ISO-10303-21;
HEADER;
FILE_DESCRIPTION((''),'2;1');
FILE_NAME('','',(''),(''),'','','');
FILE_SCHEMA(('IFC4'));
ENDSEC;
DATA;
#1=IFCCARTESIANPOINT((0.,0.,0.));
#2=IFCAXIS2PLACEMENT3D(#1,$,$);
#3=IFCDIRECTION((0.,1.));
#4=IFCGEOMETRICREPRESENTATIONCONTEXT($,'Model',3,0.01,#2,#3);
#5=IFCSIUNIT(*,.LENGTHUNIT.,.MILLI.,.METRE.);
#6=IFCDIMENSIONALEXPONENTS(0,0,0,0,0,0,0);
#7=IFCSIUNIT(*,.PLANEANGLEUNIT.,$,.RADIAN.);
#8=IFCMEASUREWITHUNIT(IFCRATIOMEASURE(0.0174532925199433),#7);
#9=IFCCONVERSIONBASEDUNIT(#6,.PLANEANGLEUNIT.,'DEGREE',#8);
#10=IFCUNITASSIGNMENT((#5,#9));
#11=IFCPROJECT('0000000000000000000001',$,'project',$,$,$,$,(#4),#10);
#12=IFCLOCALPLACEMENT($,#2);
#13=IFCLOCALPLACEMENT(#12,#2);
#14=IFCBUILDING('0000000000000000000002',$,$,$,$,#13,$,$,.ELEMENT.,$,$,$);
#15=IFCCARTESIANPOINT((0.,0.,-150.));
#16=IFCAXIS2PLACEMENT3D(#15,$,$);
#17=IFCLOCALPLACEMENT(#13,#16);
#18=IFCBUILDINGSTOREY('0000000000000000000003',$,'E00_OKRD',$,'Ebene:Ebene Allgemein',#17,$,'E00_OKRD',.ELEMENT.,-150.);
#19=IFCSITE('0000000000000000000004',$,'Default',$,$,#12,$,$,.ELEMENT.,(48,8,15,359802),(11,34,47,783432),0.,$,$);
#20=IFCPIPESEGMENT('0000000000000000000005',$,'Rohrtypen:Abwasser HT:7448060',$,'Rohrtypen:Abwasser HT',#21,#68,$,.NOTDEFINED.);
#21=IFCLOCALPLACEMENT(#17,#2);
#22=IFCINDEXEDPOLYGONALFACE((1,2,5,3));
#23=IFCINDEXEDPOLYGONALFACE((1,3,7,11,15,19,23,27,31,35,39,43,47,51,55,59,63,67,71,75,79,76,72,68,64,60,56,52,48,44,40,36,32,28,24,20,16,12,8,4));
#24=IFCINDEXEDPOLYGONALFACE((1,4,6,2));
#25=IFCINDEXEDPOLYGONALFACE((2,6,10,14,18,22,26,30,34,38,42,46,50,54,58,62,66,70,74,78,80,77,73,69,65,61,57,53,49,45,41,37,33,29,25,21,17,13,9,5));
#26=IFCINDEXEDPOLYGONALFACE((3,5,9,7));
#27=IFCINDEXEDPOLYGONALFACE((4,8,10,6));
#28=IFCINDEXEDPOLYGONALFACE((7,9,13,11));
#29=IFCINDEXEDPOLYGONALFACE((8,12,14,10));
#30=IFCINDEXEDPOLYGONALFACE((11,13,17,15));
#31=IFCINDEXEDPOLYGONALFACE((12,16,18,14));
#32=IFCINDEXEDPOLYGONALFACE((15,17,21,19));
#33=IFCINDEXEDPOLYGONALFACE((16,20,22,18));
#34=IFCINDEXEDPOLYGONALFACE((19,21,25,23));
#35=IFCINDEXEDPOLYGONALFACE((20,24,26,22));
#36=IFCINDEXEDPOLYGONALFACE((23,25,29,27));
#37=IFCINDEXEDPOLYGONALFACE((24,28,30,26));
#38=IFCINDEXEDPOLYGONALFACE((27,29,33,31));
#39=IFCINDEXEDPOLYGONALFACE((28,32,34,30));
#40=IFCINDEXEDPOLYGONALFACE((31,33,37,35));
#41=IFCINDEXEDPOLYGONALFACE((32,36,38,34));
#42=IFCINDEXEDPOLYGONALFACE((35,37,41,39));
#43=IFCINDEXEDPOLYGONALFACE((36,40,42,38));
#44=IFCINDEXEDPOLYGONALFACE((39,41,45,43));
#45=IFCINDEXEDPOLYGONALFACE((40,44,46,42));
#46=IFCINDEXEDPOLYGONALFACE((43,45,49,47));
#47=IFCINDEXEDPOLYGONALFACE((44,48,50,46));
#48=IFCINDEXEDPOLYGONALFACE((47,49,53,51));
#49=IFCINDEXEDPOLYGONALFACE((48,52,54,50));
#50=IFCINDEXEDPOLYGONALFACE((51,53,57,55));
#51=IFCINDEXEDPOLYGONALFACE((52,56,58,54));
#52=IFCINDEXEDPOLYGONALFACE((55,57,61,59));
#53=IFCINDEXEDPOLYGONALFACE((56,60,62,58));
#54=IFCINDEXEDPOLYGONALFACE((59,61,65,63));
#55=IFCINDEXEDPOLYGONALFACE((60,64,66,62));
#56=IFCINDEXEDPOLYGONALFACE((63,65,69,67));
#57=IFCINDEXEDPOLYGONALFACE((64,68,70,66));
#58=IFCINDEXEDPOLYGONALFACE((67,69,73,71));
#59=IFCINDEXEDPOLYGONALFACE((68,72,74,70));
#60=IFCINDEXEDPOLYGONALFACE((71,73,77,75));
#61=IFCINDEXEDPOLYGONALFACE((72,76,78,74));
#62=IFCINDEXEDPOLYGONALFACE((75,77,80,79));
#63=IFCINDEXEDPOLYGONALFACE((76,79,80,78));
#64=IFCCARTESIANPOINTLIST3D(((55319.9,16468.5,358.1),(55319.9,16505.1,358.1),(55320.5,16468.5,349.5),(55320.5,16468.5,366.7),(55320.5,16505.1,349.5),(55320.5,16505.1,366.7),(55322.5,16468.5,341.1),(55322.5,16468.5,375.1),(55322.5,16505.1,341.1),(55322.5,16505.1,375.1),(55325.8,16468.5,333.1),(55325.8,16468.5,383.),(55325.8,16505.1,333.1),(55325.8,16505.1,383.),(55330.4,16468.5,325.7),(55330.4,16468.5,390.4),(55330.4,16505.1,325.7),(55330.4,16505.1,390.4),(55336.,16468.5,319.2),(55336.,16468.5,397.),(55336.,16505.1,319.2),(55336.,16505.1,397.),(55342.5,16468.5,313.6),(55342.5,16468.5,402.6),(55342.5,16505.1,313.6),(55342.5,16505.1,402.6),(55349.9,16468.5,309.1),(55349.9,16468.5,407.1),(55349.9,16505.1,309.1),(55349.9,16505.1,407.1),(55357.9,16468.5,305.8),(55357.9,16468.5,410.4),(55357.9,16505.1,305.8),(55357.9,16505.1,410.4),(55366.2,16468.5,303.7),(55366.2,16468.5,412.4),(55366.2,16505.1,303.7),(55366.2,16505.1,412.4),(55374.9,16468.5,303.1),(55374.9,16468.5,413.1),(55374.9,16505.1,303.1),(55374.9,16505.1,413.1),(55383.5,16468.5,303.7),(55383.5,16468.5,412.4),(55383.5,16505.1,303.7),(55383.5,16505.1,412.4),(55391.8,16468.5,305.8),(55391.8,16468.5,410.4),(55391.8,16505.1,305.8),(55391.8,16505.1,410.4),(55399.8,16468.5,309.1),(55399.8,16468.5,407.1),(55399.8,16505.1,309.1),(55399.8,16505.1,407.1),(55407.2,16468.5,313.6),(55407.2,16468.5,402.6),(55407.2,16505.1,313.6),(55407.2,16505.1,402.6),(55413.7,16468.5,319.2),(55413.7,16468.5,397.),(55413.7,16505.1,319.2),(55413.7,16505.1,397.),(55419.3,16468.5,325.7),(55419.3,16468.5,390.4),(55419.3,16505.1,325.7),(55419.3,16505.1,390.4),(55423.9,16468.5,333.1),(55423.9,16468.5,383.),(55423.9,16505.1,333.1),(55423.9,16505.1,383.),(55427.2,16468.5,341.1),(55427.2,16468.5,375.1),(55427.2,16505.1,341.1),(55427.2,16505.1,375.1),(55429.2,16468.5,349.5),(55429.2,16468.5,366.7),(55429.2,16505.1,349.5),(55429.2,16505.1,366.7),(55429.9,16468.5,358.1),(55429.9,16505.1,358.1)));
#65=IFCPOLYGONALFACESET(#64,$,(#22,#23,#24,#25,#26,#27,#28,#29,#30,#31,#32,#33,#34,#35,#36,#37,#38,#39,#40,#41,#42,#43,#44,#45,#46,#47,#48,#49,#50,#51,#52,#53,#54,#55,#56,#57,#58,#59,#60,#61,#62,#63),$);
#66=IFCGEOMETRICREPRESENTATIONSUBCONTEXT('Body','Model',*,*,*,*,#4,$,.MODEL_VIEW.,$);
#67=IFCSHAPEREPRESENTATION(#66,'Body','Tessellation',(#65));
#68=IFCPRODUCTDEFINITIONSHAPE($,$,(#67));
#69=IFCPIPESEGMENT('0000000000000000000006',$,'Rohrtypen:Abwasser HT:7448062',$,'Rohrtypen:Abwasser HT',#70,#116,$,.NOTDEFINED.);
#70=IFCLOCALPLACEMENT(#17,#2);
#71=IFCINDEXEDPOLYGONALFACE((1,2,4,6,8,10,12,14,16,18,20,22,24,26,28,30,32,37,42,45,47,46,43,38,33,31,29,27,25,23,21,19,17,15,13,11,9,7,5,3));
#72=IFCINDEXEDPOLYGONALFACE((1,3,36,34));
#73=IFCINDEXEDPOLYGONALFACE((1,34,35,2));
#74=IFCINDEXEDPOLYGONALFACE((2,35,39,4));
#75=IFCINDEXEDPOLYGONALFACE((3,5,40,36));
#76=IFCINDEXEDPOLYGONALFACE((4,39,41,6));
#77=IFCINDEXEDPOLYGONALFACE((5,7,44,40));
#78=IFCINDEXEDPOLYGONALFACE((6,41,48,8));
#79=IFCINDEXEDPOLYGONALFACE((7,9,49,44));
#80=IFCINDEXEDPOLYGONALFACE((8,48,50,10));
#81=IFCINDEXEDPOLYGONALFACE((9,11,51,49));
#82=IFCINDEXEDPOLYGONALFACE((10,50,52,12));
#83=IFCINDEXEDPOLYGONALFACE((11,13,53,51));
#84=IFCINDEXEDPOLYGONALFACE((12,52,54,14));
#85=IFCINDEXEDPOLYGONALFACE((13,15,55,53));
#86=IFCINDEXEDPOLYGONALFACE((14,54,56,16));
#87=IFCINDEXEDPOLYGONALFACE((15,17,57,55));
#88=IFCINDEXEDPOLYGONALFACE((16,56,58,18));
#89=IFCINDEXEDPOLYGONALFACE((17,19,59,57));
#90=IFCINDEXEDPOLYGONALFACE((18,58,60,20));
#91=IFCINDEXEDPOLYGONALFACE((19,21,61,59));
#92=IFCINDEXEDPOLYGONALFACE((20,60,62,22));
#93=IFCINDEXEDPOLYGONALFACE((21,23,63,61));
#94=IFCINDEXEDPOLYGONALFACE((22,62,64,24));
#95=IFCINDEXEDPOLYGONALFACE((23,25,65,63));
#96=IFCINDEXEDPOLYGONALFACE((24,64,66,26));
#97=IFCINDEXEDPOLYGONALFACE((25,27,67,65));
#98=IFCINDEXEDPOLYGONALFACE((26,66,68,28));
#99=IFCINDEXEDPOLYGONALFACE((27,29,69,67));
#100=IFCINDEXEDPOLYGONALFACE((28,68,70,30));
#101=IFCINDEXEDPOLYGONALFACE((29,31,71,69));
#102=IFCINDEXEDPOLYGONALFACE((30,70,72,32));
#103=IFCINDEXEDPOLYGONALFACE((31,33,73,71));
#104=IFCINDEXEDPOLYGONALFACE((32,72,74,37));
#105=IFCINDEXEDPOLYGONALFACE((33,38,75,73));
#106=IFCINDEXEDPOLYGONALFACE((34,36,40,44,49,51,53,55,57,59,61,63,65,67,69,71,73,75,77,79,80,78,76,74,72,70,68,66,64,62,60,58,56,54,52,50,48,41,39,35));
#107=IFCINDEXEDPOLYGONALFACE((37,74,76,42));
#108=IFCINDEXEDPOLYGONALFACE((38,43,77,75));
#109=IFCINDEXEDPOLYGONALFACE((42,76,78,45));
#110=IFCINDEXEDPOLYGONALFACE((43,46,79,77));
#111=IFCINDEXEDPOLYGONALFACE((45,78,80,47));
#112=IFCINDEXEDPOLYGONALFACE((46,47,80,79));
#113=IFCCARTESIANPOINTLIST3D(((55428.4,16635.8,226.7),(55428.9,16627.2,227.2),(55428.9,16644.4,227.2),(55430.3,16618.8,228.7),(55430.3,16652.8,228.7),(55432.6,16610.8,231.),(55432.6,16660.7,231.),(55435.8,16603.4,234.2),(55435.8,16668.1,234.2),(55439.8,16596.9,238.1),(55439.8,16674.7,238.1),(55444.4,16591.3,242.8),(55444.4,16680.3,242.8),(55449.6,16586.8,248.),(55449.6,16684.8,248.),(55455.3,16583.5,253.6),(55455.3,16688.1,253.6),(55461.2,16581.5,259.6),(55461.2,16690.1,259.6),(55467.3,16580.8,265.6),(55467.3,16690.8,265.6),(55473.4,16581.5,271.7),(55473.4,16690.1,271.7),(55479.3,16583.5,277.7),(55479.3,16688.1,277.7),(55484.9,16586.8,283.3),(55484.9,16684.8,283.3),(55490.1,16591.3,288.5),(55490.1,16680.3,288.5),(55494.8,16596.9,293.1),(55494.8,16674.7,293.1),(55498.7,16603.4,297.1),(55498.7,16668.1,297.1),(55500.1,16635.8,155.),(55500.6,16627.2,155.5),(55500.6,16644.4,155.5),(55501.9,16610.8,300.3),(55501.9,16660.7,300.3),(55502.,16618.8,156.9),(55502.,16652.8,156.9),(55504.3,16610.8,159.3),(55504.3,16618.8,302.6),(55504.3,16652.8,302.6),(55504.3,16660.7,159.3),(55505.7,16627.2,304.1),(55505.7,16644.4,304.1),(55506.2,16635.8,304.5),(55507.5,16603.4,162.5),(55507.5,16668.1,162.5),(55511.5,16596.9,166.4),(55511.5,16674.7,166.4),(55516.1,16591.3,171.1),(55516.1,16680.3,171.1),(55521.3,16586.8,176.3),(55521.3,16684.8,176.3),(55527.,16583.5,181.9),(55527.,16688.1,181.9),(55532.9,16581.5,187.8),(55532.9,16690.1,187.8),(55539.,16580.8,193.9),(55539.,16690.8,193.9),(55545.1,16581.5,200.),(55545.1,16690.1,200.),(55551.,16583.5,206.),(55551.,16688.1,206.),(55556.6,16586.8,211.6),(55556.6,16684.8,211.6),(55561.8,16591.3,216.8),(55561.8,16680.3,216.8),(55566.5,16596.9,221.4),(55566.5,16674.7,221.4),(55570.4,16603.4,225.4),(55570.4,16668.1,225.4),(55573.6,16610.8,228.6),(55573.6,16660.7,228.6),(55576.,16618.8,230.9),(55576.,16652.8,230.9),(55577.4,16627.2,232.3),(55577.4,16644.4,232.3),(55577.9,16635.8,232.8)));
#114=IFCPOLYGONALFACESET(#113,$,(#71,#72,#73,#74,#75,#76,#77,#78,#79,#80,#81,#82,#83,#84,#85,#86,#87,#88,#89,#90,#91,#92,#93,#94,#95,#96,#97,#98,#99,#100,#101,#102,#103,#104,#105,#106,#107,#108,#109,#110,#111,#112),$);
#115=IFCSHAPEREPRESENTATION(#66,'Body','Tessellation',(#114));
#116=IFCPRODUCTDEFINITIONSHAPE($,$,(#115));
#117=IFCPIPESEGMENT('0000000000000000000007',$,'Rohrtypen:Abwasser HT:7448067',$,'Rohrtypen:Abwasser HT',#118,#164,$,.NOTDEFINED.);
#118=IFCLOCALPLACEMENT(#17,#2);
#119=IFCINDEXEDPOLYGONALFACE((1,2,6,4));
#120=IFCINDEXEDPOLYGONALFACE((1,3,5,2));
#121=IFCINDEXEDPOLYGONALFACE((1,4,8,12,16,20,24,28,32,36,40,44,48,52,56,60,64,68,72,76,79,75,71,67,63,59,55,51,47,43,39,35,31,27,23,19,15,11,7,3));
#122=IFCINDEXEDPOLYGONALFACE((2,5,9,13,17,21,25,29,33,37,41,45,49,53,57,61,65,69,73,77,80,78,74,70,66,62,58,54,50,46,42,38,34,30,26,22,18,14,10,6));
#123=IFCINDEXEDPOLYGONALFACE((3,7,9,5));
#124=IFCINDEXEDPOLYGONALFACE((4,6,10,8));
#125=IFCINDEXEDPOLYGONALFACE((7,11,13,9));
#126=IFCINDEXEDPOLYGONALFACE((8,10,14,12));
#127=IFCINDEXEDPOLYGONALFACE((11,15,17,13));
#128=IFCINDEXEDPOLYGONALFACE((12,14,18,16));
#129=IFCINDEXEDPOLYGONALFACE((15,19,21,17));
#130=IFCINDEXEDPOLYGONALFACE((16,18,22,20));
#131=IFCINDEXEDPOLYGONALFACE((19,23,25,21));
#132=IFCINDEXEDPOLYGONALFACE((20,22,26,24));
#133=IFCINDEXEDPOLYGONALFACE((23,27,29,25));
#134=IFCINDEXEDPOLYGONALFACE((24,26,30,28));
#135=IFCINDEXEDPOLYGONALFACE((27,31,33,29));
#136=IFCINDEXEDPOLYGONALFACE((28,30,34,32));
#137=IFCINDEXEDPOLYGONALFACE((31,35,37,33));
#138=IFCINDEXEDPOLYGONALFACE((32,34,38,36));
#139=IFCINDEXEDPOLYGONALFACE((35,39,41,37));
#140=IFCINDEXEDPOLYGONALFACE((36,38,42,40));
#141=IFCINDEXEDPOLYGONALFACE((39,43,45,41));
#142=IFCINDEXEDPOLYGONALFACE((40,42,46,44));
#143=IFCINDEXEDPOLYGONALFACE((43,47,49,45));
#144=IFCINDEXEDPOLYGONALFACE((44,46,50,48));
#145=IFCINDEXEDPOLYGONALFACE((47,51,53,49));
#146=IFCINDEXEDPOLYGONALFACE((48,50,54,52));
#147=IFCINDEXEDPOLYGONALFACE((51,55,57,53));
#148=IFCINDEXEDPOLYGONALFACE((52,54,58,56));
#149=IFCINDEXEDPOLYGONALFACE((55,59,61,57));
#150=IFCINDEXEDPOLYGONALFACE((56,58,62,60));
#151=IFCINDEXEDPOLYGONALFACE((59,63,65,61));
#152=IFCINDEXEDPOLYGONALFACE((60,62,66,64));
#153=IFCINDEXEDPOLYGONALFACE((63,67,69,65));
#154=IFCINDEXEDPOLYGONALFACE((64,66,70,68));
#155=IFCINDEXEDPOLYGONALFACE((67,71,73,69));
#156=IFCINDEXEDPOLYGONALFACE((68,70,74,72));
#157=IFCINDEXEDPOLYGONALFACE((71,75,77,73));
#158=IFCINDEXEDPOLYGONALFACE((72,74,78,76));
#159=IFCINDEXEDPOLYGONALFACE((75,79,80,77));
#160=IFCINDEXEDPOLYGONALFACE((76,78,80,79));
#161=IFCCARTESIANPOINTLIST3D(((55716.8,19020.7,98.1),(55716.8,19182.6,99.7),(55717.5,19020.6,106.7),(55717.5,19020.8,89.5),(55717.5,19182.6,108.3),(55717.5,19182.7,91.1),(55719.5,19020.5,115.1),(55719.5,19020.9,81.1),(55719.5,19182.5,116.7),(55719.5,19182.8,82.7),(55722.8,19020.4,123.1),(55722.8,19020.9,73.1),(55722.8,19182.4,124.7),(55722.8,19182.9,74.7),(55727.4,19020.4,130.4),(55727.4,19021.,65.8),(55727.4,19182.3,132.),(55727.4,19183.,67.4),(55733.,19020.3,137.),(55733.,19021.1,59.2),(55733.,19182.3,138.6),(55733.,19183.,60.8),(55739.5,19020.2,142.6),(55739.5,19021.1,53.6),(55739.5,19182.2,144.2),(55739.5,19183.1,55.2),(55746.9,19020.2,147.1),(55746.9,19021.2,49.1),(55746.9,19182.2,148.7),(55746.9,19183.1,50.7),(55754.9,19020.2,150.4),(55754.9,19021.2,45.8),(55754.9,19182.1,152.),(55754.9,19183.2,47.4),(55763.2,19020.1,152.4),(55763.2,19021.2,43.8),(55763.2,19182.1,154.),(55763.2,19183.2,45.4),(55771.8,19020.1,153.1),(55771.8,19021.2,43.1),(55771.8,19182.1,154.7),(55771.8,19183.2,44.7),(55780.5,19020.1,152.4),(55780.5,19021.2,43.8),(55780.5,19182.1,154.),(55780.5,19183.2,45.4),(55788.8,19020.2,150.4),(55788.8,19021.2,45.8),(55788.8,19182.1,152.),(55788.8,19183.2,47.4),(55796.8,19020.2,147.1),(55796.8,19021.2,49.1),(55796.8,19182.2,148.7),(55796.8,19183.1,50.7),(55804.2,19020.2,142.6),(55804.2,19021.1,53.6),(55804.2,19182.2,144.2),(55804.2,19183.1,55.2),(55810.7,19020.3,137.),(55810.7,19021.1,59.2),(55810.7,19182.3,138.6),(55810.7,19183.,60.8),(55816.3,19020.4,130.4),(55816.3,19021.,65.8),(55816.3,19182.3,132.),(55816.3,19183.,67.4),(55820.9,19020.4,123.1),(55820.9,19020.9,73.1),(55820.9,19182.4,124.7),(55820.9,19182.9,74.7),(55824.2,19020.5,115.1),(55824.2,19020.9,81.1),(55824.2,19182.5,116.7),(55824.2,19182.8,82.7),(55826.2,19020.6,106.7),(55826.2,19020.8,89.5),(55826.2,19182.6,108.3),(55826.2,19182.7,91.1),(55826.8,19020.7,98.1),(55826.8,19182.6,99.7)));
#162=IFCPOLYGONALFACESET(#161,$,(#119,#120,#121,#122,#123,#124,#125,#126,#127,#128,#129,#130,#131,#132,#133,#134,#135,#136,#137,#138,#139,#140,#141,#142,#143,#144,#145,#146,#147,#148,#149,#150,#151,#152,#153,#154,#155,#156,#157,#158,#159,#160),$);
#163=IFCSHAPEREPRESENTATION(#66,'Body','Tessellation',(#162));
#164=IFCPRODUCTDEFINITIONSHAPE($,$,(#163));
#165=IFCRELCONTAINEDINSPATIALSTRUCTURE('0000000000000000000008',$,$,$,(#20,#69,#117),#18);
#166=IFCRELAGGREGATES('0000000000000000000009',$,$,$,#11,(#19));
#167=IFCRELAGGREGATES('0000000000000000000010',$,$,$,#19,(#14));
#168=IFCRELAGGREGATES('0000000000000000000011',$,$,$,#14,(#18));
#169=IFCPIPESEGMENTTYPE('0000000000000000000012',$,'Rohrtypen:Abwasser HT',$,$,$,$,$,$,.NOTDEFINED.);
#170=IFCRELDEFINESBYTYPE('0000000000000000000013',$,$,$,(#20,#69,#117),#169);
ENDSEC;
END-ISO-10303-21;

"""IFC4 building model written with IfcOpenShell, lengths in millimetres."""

from ifc_helpers import new_model, entity, si_unit, converted_unit, direction, frame, origin, place, context, subcontext, project, spatial, indexed_curve, outline, extrude, type_object, element, save


model = new_model("IFC4")

# Units and contexts
model_context = context("Model", 3, precision=0.01, world=origin(), true_north=direction((0.0, 1.0)))
body_context = subcontext(model_context, "Body", "Model", "MODEL_VIEW")
ifc_project = project(units=[si_unit("LENGTHUNIT", "METRE", prefix="MILLI"), converted_unit("PLANEANGLEUNIT", "DEGREE", entity("IfcRatioMeasure", 0.0174532925199433), si_unit("PLANEANGLEUNIT", "RADIAN"), dimensions=[0, 0, 0, 0, 0, 0, 0])], contexts=[model_context])

# Site, building, storey
site_placement = place(None, origin())
site = spatial("IfcSite", under=ifc_project, at=site_placement, Name="Default", CompositionType="ELEMENT", RefLatitude=(48, 8, 15, 359802), RefLongitude=(11, 34, 47, 783432), RefElevation=0.0)
building_placement = place(site_placement, origin())
building = spatial("IfcBuilding", under=site, at=building_placement, CompositionType="ELEMENT")
storey_placement = place(building_placement, frame((0.0, 0.0, -150.0)))
storey = spatial("IfcBuildingStorey", under=building, at=storey_placement, Name="E00_OKRD", ObjectType="Ebene:Ebene Allgemein", LongName="E00_OKRD", CompositionType="ELEMENT", Elevation=-150.0)

# Pipe segments
pipe_segment_type_1 = type_object("IfcPipeSegmentType", Name="Rohrtypen:Abwasser HT", PredefinedType="NOTDEFINED")
pipe_segment_1_placement = place(storey_placement, origin())
element("IfcPipeSegment", 1, at=pipe_segment_1_placement, inside=storey, type_object=pipe_segment_type_1, Name="Rohrtypen:Abwasser HT:7448060", ObjectType="Rohrtypen:Abwasser HT", PredefinedType="NOTDEFINED", context=body_context, shape_type="SweptSolid", body=[
    extrude(outline(indexed_curve([(55.0, 0.0), (54.3, 8.6), (52.3, 17.0), (49.0, 25.0), (44.5, 32.3), (38.9, 38.9), (32.3, 44.5), (25.0, 49.0), (17.0, 52.3), (8.6, 54.3), (0.0, 55.0), (-8.6, 54.3), (-17.0, 52.3), (-25.0, 49.0), (-32.3, 44.5), (-38.9, 38.9), (-44.5, 32.3), (-49.0, 25.0), (-52.3, 17.0), (-54.3, 8.6), (-55.0, 0.0), (-54.3, -8.6), (-52.3, -17.0), (-49.0, -25.0), (-44.5, -32.3), (-38.9, -38.9), (-32.3, -44.5), (-25.0, -49.0), (-17.0, -52.3), (-8.6, -54.3), (0.0, -55.0), (8.6, -54.3), (17.0, -52.3), (25.0, -49.0), (32.3, -44.5), (38.9, -38.9), (44.5, -32.3), (49.0, -25.0), (52.3, -17.0), (54.3, -8.6), (55.0, 0.0)], self_intersect=False)), frame((55374.9, 16468.5, 358.1), z_axis=(-0.000001, 1.0, 0.0), x_axis=(1.0, 0.000001, 0.0)), (0.0, 0.0, 1.0), 36.5),
])
pipe_segment_2_placement = place(storey_placement, origin())
element("IfcPipeSegment", 2, at=pipe_segment_2_placement, inside=storey, type_object=pipe_segment_type_1, Name="Rohrtypen:Abwasser HT:7448062", ObjectType="Rohrtypen:Abwasser HT", PredefinedType="NOTDEFINED", context=body_context, shape_type="SweptSolid", body=[
    extrude(outline(indexed_curve([(55.0, 0.0), (54.3, 8.6), (52.3, 17.0), (49.0, 25.0), (44.5, 32.3), (38.9, 38.9), (32.3, 44.5), (25.0, 49.0), (17.0, 52.3), (8.6, 54.3), (0.0, 55.0), (-8.6, 54.3), (-17.0, 52.3), (-25.0, 49.0), (-32.3, 44.5), (-38.9, 38.9), (-44.5, 32.3), (-49.0, 25.0), (-52.3, 17.0), (-54.3, 8.6), (-55.0, 0.0), (-54.3, -8.6), (-52.3, -17.0), (-49.0, -25.0), (-44.5, -32.3), (-38.9, -38.9), (-32.3, -44.5), (-25.0, -49.0), (-17.0, -52.3), (-8.6, -54.3), (0.0, -55.0), (8.6, -54.3), (17.0, -52.3), (25.0, -49.0), (32.3, -44.5), (38.9, -38.9), (44.5, -32.3), (49.0, -25.0), (52.3, -17.0), (54.3, -8.6), (55.0, 0.0)], self_intersect=False)), frame((55539.0, 16635.8, 193.9), z_axis=(-0.707107, 0.0, 0.707107), x_axis=(0.0, -1.0, 0.0)), (0.0, 0.0, 1.0), 101.4),
])
pipe_segment_3_placement = place(storey_placement, origin())
element("IfcPipeSegment", 3, at=pipe_segment_3_placement, inside=storey, type_object=pipe_segment_type_1, Name="Rohrtypen:Abwasser HT:7448067", ObjectType="Rohrtypen:Abwasser HT", PredefinedType="NOTDEFINED", context=body_context, shape_type="SweptSolid", body=[
    extrude(outline(indexed_curve([(55.0, 0.0), (54.3, 8.6), (52.3, 17.0), (49.0, 25.0), (44.5, 32.3), (38.9, 38.9), (32.3, 44.5), (25.0, 49.0), (17.0, 52.3), (8.6, 54.3), (0.0, 55.0), (-8.6, 54.3), (-17.0, 52.3), (-25.0, 49.0), (-32.3, 44.5), (-38.9, 38.9), (-44.5, 32.3), (-49.0, 25.0), (-52.3, 17.0), (-54.3, 8.6), (-55.0, 0.0), (-54.3, -8.6), (-52.3, -17.0), (-49.0, -25.0), (-44.5, -32.3), (-38.9, -38.9), (-32.3, -44.5), (-25.0, -49.0), (-17.0, -52.3), (-8.6, -54.3), (0.0, -55.0), (8.6, -54.3), (17.0, -52.3), (25.0, -49.0), (32.3, -44.5), (38.9, -38.9), (44.5, -32.3), (49.0, -25.0), (52.3, -17.0), (54.3, -8.6), (55.0, 0.0)], self_intersect=False)), frame((55771.8, 19020.7, 98.1), z_axis=(0.0, 0.99995, 0.01), x_axis=(1.0, 0.0, 0.0)), (0.0, 0.0, 1.0), 162.0),
])

save(model, "model.ifc")
